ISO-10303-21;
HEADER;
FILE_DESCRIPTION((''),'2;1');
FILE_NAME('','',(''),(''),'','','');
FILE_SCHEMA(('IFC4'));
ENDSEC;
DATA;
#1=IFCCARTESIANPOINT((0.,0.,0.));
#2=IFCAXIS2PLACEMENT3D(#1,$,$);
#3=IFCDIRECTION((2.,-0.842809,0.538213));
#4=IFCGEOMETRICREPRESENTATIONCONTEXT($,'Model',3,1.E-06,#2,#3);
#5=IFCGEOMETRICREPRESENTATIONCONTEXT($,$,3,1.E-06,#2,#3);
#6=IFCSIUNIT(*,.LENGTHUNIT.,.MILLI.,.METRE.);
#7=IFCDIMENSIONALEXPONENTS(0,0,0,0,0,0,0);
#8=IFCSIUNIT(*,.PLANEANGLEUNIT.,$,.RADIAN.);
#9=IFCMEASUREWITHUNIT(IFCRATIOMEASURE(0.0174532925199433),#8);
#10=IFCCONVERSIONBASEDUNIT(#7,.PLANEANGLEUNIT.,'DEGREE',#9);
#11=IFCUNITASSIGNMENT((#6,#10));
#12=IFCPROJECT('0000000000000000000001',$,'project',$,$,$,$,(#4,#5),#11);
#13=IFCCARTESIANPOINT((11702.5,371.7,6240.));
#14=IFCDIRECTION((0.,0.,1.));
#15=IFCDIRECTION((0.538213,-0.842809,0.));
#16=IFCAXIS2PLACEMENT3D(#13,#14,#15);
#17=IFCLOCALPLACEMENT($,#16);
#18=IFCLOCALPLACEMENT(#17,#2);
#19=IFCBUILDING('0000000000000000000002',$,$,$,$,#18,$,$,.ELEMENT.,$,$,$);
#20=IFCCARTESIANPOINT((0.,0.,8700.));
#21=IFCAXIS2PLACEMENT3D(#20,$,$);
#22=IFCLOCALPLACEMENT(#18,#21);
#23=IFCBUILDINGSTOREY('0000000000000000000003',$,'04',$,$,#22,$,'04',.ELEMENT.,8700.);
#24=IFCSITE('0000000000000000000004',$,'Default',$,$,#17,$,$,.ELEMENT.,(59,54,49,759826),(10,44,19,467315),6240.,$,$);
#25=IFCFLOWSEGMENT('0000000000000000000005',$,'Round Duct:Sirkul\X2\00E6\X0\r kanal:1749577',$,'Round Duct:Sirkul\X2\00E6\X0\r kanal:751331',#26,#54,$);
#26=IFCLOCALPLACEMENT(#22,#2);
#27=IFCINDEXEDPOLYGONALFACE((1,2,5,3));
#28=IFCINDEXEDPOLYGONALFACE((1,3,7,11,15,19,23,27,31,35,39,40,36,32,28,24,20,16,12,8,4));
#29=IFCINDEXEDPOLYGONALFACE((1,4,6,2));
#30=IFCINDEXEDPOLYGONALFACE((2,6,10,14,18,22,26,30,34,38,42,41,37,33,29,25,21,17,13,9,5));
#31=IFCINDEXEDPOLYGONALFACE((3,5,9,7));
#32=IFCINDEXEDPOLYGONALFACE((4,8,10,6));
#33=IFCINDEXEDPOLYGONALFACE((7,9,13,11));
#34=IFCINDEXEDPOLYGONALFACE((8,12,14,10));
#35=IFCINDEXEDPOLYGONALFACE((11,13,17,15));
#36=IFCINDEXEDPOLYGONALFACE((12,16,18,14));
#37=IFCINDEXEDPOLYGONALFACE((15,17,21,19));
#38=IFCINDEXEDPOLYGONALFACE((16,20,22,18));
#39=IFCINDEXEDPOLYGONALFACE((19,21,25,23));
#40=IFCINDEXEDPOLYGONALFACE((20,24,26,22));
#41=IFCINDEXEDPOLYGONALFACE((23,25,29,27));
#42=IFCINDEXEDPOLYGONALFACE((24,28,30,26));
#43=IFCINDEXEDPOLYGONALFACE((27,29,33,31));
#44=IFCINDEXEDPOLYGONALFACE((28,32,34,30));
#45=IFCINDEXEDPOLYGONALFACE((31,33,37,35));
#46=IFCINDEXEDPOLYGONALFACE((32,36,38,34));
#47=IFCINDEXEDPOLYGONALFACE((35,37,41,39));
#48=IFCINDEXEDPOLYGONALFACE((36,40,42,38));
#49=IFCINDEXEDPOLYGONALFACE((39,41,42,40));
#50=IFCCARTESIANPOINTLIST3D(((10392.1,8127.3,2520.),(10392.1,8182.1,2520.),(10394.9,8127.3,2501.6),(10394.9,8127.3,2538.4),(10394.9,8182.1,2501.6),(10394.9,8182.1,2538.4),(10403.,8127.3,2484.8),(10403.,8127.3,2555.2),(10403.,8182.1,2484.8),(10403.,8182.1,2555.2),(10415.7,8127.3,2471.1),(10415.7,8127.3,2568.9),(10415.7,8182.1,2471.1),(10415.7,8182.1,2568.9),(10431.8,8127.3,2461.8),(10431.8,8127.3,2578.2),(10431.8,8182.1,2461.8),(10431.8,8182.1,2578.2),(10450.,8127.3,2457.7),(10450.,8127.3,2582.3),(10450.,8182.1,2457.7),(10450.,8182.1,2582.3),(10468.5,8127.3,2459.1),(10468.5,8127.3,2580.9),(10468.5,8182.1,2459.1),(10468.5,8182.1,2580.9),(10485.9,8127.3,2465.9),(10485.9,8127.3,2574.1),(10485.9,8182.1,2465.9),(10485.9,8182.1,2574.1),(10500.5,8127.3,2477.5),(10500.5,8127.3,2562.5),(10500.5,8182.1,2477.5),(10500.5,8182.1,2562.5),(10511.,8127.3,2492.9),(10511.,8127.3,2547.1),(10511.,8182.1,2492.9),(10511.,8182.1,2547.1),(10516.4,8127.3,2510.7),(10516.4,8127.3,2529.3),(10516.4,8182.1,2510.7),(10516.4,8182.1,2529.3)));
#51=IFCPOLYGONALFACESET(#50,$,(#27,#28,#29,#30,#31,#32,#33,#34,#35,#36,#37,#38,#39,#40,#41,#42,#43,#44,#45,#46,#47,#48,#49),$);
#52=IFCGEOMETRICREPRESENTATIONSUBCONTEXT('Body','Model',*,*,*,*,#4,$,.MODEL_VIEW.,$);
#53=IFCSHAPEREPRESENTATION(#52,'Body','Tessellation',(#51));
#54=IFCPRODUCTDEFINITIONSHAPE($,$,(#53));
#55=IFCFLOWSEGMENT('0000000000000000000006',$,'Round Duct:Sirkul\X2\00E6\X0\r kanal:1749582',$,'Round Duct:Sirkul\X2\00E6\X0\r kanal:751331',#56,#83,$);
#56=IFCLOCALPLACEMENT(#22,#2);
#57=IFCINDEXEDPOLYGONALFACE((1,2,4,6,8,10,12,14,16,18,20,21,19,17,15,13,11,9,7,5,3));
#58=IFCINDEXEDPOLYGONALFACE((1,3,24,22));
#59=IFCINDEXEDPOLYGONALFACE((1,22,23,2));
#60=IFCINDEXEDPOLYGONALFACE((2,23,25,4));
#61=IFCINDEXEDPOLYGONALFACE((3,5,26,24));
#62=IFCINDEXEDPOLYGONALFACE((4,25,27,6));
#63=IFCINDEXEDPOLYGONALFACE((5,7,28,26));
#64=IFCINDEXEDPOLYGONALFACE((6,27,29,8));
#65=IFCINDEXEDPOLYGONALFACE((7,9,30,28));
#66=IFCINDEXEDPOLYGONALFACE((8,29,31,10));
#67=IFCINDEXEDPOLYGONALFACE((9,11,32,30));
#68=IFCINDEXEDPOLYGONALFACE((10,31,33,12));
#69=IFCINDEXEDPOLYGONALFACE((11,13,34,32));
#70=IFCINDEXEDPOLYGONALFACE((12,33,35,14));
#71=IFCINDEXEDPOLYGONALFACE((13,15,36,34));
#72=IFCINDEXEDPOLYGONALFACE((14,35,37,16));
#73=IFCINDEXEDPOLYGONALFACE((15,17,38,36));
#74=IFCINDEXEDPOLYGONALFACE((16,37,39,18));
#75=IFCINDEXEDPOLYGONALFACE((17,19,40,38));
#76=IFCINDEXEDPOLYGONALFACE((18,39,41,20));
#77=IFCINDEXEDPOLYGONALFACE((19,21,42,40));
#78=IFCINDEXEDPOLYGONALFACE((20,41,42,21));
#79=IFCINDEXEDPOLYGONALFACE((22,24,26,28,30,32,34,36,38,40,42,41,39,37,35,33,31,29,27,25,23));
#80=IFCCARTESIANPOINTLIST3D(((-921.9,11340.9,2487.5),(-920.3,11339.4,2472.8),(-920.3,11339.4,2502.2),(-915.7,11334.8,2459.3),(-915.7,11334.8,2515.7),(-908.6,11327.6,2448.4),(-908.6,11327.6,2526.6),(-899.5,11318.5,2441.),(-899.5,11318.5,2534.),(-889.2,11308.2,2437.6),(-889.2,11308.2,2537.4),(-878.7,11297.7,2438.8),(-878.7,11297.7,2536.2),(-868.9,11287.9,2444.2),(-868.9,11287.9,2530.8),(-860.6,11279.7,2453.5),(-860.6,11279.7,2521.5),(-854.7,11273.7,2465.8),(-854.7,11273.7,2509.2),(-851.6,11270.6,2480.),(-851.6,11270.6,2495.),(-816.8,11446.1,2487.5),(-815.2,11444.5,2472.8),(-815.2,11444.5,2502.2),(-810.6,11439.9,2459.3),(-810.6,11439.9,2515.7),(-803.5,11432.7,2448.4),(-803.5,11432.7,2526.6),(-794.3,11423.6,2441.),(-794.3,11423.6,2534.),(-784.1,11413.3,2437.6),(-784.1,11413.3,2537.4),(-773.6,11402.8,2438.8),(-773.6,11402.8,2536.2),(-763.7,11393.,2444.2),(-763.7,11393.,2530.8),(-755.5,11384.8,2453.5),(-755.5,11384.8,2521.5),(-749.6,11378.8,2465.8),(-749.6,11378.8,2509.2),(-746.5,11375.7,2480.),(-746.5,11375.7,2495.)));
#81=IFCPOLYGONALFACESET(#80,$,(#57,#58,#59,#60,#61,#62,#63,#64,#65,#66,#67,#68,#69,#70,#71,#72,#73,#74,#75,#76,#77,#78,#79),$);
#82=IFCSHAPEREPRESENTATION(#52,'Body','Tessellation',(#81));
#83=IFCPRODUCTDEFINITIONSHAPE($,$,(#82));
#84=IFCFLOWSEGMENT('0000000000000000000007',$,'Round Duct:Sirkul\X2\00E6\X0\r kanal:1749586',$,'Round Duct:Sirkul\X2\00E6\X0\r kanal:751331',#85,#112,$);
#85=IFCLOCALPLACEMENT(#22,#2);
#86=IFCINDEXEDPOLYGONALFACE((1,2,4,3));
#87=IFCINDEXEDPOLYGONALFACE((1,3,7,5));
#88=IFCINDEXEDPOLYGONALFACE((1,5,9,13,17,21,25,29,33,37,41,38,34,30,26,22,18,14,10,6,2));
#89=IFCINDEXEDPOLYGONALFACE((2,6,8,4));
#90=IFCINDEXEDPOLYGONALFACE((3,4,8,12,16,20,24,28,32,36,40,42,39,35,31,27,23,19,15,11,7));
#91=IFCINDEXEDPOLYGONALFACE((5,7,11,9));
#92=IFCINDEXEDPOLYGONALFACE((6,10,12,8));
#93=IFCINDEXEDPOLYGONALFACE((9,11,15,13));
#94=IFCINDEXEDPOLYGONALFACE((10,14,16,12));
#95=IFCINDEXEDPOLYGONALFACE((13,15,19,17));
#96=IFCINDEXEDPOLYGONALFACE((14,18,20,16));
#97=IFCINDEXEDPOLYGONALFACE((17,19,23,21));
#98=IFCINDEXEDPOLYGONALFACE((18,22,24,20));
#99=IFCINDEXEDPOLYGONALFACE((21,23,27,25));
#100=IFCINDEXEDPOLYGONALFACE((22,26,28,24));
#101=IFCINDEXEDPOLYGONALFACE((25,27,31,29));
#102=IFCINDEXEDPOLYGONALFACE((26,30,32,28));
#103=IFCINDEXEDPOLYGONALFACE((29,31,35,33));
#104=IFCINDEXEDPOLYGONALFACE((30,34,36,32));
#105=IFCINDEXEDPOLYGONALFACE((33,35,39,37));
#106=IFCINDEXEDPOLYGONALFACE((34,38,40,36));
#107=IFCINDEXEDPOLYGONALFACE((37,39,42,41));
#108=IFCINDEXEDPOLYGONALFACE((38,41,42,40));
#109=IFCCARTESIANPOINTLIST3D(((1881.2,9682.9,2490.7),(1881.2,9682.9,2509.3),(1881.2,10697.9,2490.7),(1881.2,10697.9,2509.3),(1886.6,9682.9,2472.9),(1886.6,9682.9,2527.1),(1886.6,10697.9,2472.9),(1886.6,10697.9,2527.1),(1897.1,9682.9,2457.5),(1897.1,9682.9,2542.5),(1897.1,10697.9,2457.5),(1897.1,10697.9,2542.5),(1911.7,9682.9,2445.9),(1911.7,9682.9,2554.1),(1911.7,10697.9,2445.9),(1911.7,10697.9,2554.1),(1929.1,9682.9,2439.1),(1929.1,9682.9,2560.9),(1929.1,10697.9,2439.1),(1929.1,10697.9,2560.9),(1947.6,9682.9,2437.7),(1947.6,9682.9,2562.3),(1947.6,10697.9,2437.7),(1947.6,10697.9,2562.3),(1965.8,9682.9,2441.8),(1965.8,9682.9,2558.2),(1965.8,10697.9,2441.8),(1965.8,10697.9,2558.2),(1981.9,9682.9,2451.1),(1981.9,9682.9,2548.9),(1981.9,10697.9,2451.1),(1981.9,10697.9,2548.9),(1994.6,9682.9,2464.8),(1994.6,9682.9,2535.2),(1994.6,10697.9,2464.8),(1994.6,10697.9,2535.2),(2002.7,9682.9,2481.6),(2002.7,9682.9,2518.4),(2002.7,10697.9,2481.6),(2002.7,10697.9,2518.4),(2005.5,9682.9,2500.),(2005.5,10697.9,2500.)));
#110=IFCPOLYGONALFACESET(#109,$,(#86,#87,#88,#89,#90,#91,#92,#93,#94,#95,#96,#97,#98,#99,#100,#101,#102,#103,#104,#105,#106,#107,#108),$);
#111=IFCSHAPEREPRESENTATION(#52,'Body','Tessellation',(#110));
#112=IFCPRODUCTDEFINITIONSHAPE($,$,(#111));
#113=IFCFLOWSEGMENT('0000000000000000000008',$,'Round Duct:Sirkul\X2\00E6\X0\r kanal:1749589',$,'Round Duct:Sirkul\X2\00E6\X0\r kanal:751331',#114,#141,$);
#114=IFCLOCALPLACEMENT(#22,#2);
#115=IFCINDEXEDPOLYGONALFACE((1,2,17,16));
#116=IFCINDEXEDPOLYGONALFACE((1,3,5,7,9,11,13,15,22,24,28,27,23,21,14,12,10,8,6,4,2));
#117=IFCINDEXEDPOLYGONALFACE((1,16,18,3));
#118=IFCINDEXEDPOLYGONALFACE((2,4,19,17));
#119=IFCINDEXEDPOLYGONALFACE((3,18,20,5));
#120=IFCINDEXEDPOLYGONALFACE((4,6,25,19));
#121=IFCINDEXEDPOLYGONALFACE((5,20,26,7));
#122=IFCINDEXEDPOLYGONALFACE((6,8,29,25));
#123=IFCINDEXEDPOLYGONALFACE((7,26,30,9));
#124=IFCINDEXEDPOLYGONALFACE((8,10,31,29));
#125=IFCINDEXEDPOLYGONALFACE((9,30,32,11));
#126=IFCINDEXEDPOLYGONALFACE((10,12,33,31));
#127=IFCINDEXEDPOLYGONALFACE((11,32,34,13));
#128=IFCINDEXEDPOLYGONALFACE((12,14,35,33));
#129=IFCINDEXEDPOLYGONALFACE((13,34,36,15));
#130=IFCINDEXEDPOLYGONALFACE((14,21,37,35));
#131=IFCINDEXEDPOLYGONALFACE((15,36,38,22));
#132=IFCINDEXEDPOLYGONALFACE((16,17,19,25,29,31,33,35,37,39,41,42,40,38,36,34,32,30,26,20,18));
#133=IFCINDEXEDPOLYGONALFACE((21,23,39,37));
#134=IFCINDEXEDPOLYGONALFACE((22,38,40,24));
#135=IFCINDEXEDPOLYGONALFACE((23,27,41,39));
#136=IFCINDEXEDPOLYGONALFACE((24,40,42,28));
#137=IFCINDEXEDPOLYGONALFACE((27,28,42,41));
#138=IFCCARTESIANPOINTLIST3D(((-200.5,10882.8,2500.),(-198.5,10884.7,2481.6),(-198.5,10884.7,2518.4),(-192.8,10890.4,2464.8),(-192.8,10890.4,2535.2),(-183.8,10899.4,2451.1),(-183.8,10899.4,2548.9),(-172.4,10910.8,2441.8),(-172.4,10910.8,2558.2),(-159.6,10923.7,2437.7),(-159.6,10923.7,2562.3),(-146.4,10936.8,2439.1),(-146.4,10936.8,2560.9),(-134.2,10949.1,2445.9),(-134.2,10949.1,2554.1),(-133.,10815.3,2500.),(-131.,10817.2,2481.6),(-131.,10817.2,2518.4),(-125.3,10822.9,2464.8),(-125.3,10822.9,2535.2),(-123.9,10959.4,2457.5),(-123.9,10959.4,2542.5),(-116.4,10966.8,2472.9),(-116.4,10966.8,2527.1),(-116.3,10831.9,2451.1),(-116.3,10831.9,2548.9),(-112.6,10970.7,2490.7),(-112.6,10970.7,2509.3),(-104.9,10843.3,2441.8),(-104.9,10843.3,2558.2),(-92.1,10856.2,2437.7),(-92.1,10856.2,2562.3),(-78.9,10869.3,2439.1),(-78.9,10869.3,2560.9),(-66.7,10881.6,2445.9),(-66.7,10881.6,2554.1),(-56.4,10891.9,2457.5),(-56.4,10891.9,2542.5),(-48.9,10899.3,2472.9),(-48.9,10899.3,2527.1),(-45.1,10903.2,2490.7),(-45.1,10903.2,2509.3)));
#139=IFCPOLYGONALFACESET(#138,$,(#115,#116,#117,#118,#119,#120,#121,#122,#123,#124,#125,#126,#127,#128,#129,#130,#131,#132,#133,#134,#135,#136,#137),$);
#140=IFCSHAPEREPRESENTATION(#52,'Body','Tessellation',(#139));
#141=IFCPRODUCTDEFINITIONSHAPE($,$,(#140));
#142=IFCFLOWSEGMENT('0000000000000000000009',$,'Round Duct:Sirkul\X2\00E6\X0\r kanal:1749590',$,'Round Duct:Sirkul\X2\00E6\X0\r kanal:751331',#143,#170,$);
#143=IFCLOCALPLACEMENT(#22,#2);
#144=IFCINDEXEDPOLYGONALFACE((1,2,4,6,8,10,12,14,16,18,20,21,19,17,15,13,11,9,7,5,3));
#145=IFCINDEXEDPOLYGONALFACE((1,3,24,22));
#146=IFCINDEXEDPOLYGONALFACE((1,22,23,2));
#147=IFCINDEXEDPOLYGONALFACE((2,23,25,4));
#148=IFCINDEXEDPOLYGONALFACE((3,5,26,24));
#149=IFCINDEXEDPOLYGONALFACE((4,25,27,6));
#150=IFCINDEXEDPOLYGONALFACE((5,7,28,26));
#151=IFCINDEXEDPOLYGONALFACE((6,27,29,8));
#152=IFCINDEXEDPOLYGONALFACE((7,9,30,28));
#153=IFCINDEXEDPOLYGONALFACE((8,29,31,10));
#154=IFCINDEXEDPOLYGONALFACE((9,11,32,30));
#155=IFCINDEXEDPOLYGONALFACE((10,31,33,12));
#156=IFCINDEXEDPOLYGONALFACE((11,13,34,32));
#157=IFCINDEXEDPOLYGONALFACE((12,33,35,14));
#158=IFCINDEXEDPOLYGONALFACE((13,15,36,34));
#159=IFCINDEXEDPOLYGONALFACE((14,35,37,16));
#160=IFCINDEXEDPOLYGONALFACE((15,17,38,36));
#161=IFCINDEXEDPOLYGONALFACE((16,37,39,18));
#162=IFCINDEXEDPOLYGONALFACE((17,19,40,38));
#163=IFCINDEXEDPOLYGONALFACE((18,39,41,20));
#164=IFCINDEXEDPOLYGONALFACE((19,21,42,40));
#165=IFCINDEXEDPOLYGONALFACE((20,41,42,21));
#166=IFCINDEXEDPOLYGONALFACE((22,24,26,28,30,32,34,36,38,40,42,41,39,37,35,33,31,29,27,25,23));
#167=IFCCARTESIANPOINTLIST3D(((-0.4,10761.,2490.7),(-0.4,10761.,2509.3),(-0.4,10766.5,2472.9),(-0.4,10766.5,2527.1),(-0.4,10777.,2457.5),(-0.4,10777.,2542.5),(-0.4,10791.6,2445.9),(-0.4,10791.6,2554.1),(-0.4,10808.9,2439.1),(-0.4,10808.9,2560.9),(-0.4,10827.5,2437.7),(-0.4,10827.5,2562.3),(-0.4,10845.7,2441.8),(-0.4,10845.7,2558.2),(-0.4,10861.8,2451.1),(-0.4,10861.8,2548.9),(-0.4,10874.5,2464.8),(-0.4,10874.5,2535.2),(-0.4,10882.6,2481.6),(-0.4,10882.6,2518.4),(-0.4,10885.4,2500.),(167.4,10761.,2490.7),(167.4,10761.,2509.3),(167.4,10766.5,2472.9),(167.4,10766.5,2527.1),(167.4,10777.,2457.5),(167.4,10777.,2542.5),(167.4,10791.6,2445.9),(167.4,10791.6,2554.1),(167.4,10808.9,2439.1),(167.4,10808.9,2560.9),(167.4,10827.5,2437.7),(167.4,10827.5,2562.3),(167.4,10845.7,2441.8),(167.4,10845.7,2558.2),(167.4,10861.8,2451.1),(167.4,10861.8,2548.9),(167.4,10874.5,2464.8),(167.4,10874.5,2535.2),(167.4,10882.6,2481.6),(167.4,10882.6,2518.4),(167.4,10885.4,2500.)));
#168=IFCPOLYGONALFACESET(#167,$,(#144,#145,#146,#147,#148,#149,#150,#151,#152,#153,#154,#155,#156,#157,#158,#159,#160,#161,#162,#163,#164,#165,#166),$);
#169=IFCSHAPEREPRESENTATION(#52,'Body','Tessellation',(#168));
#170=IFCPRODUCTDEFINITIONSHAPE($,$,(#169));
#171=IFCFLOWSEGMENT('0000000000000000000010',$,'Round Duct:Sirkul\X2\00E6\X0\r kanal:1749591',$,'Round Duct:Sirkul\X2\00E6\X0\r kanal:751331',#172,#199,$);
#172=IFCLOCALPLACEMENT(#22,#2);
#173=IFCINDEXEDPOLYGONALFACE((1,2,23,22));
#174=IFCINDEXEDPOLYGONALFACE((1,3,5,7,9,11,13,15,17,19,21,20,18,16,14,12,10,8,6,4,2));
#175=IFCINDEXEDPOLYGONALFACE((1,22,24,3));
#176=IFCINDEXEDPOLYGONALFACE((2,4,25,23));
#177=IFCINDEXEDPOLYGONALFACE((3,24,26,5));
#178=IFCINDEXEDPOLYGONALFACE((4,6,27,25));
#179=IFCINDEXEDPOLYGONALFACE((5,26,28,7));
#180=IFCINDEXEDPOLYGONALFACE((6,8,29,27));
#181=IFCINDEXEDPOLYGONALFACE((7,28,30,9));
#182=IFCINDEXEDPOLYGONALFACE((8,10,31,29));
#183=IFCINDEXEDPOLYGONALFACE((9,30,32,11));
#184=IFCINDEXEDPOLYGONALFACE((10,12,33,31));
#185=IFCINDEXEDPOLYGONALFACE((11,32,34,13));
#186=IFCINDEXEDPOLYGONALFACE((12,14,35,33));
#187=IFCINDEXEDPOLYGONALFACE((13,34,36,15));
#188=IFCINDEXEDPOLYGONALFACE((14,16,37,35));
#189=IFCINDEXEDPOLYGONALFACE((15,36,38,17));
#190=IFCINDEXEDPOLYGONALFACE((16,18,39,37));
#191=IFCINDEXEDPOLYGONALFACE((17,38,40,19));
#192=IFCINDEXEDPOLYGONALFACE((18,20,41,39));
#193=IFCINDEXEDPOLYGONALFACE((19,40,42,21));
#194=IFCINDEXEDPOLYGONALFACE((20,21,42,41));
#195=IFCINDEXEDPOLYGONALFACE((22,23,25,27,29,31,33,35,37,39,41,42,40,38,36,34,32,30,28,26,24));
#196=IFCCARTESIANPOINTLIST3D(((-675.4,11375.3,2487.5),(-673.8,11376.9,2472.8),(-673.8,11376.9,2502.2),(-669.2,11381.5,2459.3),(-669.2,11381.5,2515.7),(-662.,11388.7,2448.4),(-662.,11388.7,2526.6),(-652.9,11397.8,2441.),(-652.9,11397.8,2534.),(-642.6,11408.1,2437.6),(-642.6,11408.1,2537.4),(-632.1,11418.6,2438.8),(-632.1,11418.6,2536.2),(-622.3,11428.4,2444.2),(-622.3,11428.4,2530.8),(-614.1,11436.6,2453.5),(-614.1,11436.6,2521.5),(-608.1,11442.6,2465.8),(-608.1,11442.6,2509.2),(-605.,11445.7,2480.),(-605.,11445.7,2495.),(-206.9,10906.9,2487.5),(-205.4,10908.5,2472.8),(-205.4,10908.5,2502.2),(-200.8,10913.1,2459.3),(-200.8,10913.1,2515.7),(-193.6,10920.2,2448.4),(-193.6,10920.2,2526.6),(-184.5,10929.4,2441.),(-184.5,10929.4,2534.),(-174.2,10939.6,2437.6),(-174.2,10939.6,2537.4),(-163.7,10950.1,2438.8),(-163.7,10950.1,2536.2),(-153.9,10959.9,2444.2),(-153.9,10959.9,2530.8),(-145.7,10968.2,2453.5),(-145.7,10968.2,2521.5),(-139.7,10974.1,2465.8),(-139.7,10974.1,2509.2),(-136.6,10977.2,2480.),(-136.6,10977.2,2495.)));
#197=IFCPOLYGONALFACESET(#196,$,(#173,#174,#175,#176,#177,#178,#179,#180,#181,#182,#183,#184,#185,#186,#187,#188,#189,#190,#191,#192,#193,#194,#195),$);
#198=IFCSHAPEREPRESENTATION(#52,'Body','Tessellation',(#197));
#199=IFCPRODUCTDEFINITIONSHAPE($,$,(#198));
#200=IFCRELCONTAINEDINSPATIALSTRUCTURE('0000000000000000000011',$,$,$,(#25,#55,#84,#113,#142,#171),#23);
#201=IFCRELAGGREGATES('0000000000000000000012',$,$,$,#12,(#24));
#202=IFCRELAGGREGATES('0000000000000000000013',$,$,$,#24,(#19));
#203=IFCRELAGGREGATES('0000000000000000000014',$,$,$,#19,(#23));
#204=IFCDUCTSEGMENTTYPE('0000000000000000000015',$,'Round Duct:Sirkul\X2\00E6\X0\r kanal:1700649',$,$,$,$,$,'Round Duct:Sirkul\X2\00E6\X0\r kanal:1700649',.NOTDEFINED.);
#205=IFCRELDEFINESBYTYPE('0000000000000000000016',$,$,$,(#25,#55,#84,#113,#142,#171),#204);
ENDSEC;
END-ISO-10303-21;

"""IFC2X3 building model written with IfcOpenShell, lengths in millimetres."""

from ifc_helpers import new_model, entity, si_unit, converted_unit, direction, frame, frame_2d, origin, origin_2d_with_axis, place, context, subcontext, project, spatial, circle, extrude, type_object, element, save


model = new_model("IFC2X3")

# Units and contexts
model_context = context("Model", 3, precision=1e-06, world=origin(), true_north=direction((2.0, -0.842809, 0.538213)))
context_of_model = context(None, 3, precision=1e-06, world=origin(), true_north=direction((2.0, -0.842809, 0.538213)))
body_context = subcontext(model_context, "Body", "Model", "MODEL_VIEW")
ifc_project = project(units=[si_unit("LENGTHUNIT", "METRE", prefix="MILLI"), converted_unit("PLANEANGLEUNIT", "DEGREE", entity("IfcRatioMeasure", 0.0174532925199433), si_unit("PLANEANGLEUNIT", "RADIAN"), dimensions=[0, 0, 0, 0, 0, 0, 0])], contexts=[model_context, context_of_model])

# Site, building, storey
site_placement = place(None, frame((11702.5, 371.7, 6240.0), z_axis=(0.0, 0.0, 1.0), x_axis=(0.538213, -0.842809, 0.0)))
site = spatial("IfcSite", under=ifc_project, at=site_placement, Name="Default", CompositionType="ELEMENT", RefLatitude=(59, 54, 49, 759826), RefLongitude=(10, 44, 19, 467315), RefElevation=6240.0)
building_placement = place(site_placement, origin())
building = spatial("IfcBuilding", under=site, at=building_placement, CompositionType="ELEMENT")
storey_placement = place(building_placement, frame((0.0, 0.0, 8700.0)))
storey = spatial("IfcBuildingStorey", under=building, at=storey_placement, Name="04", LongName="04", CompositionType="ELEMENT", Elevation=8700.0)

# Flow segments
duct_segment_type_1 = type_object("IfcDuctSegmentType", Name="Round Duct:Sirkulær kanal:1700649", ElementType="Round Duct:Sirkulær kanal:1700649", PredefinedType="NOTDEFINED")
flow_segment_1_placement = place(storey_placement, origin())
element("IfcFlowSegment", 1, at=flow_segment_1_placement, inside=storey, type_object=duct_segment_type_1, Name="Round Duct:Sirkulær kanal:1749577", ObjectType="Round Duct:Sirkulær kanal:751331", context=body_context, shape_type="SweptSolid", body=[
    extrude(circle(Radius=62.5, at=origin_2d_with_axis()), frame((10454.6, 8127.3, 2520.0), z_axis=(0.0, 1.0, 0.0), x_axis=(-1.0, 0.0, 0.0)), (0.0, 0.0, 1.0), 54.8),
])
flow_segment_2_placement = place(storey_placement, origin())
element("IfcFlowSegment", 2, at=flow_segment_2_placement, inside=storey, type_object=duct_segment_type_1, Name="Round Duct:Sirkulær kanal:1749582", ObjectType="Round Duct:Sirkulær kanal:751331", context=body_context, shape_type="SweptSolid", body=[
    extrude(circle(Radius=50.0, at=origin_2d_with_axis()), frame((-886.5, 11305.6, 2487.5), z_axis=(0.707099, 0.707115, 0.0), x_axis=(-0.707115, 0.707099, 0.0)), (0.0, 0.0, 1.0), 148.7),
])
flow_segment_3_placement = place(storey_placement, origin())
element("IfcFlowSegment", 3, at=flow_segment_3_placement, inside=storey, type_object=duct_segment_type_1, Name="Round Duct:Sirkulær kanal:1749586", ObjectType="Round Duct:Sirkulær kanal:751331", context=body_context, shape_type="SweptSolid", body=[
    extrude(circle(Radius=62.5, at=origin_2d_with_axis()), frame((1943.0, 9682.9, 2500.0), z_axis=(0.0, 1.0, 0.0), x_axis=(1.0, 0.0, 0.0)), (0.0, 0.0, 1.0), 1015.0),
])
flow_segment_4_placement = place(storey_placement, origin())
element("IfcFlowSegment", 4, at=flow_segment_4_placement, inside=storey, type_object=duct_segment_type_1, Name="Round Duct:Sirkulær kanal:1749589", ObjectType="Round Duct:Sirkulær kanal:751331", context=body_context, shape_type="SweptSolid", body=[
    extrude(circle(Radius=62.5, at=frame_2d((0.0, 0.0), x_axis=(1.0, 0.0))), frame((-156.3, 10927.0, 2500.0), z_axis=(0.707107, -0.707107, 0.0), x_axis=(-0.707107, -0.707107, 0.0)), (0.0, 0.0, 1.0), 95.5),
])
flow_segment_5_placement = place(storey_placement, origin())
element("IfcFlowSegment", 5, at=flow_segment_5_placement, inside=storey, type_object=duct_segment_type_1, Name="Round Duct:Sirkulær kanal:1749590", ObjectType="Round Duct:Sirkulær kanal:751331", context=body_context, shape_type="SweptSolid", body=[
    extrude(circle(Radius=62.5, at=origin_2d_with_axis()), frame((-0.4, 10822.9, 2500.0), z_axis=(1.0, 0.0, 0.0), x_axis=(0.0, 1.0, 0.0)), (0.0, 0.0, 1.0), 167.8),
])
flow_segment_6_placement = place(storey_placement, origin())
element("IfcFlowSegment", 6, at=flow_segment_6_placement, inside=storey, type_object=duct_segment_type_1, Name="Round Duct:Sirkulær kanal:1749591", ObjectType="Round Duct:Sirkulær kanal:751331", context=body_context, shape_type="SweptSolid", body=[
    extrude(circle(Radius=50.0, at=frame_2d((0.0, 0.0), x_axis=(1.0, 0.0))), frame((-171.6, 10942.3, 2487.5), z_axis=(-0.707107, 0.707107, 0.0), x_axis=(-0.707107, -0.707107, 0.0)), (0.0, 0.0, 1.0), 662.5),
])

save(model, "model.ifc")
